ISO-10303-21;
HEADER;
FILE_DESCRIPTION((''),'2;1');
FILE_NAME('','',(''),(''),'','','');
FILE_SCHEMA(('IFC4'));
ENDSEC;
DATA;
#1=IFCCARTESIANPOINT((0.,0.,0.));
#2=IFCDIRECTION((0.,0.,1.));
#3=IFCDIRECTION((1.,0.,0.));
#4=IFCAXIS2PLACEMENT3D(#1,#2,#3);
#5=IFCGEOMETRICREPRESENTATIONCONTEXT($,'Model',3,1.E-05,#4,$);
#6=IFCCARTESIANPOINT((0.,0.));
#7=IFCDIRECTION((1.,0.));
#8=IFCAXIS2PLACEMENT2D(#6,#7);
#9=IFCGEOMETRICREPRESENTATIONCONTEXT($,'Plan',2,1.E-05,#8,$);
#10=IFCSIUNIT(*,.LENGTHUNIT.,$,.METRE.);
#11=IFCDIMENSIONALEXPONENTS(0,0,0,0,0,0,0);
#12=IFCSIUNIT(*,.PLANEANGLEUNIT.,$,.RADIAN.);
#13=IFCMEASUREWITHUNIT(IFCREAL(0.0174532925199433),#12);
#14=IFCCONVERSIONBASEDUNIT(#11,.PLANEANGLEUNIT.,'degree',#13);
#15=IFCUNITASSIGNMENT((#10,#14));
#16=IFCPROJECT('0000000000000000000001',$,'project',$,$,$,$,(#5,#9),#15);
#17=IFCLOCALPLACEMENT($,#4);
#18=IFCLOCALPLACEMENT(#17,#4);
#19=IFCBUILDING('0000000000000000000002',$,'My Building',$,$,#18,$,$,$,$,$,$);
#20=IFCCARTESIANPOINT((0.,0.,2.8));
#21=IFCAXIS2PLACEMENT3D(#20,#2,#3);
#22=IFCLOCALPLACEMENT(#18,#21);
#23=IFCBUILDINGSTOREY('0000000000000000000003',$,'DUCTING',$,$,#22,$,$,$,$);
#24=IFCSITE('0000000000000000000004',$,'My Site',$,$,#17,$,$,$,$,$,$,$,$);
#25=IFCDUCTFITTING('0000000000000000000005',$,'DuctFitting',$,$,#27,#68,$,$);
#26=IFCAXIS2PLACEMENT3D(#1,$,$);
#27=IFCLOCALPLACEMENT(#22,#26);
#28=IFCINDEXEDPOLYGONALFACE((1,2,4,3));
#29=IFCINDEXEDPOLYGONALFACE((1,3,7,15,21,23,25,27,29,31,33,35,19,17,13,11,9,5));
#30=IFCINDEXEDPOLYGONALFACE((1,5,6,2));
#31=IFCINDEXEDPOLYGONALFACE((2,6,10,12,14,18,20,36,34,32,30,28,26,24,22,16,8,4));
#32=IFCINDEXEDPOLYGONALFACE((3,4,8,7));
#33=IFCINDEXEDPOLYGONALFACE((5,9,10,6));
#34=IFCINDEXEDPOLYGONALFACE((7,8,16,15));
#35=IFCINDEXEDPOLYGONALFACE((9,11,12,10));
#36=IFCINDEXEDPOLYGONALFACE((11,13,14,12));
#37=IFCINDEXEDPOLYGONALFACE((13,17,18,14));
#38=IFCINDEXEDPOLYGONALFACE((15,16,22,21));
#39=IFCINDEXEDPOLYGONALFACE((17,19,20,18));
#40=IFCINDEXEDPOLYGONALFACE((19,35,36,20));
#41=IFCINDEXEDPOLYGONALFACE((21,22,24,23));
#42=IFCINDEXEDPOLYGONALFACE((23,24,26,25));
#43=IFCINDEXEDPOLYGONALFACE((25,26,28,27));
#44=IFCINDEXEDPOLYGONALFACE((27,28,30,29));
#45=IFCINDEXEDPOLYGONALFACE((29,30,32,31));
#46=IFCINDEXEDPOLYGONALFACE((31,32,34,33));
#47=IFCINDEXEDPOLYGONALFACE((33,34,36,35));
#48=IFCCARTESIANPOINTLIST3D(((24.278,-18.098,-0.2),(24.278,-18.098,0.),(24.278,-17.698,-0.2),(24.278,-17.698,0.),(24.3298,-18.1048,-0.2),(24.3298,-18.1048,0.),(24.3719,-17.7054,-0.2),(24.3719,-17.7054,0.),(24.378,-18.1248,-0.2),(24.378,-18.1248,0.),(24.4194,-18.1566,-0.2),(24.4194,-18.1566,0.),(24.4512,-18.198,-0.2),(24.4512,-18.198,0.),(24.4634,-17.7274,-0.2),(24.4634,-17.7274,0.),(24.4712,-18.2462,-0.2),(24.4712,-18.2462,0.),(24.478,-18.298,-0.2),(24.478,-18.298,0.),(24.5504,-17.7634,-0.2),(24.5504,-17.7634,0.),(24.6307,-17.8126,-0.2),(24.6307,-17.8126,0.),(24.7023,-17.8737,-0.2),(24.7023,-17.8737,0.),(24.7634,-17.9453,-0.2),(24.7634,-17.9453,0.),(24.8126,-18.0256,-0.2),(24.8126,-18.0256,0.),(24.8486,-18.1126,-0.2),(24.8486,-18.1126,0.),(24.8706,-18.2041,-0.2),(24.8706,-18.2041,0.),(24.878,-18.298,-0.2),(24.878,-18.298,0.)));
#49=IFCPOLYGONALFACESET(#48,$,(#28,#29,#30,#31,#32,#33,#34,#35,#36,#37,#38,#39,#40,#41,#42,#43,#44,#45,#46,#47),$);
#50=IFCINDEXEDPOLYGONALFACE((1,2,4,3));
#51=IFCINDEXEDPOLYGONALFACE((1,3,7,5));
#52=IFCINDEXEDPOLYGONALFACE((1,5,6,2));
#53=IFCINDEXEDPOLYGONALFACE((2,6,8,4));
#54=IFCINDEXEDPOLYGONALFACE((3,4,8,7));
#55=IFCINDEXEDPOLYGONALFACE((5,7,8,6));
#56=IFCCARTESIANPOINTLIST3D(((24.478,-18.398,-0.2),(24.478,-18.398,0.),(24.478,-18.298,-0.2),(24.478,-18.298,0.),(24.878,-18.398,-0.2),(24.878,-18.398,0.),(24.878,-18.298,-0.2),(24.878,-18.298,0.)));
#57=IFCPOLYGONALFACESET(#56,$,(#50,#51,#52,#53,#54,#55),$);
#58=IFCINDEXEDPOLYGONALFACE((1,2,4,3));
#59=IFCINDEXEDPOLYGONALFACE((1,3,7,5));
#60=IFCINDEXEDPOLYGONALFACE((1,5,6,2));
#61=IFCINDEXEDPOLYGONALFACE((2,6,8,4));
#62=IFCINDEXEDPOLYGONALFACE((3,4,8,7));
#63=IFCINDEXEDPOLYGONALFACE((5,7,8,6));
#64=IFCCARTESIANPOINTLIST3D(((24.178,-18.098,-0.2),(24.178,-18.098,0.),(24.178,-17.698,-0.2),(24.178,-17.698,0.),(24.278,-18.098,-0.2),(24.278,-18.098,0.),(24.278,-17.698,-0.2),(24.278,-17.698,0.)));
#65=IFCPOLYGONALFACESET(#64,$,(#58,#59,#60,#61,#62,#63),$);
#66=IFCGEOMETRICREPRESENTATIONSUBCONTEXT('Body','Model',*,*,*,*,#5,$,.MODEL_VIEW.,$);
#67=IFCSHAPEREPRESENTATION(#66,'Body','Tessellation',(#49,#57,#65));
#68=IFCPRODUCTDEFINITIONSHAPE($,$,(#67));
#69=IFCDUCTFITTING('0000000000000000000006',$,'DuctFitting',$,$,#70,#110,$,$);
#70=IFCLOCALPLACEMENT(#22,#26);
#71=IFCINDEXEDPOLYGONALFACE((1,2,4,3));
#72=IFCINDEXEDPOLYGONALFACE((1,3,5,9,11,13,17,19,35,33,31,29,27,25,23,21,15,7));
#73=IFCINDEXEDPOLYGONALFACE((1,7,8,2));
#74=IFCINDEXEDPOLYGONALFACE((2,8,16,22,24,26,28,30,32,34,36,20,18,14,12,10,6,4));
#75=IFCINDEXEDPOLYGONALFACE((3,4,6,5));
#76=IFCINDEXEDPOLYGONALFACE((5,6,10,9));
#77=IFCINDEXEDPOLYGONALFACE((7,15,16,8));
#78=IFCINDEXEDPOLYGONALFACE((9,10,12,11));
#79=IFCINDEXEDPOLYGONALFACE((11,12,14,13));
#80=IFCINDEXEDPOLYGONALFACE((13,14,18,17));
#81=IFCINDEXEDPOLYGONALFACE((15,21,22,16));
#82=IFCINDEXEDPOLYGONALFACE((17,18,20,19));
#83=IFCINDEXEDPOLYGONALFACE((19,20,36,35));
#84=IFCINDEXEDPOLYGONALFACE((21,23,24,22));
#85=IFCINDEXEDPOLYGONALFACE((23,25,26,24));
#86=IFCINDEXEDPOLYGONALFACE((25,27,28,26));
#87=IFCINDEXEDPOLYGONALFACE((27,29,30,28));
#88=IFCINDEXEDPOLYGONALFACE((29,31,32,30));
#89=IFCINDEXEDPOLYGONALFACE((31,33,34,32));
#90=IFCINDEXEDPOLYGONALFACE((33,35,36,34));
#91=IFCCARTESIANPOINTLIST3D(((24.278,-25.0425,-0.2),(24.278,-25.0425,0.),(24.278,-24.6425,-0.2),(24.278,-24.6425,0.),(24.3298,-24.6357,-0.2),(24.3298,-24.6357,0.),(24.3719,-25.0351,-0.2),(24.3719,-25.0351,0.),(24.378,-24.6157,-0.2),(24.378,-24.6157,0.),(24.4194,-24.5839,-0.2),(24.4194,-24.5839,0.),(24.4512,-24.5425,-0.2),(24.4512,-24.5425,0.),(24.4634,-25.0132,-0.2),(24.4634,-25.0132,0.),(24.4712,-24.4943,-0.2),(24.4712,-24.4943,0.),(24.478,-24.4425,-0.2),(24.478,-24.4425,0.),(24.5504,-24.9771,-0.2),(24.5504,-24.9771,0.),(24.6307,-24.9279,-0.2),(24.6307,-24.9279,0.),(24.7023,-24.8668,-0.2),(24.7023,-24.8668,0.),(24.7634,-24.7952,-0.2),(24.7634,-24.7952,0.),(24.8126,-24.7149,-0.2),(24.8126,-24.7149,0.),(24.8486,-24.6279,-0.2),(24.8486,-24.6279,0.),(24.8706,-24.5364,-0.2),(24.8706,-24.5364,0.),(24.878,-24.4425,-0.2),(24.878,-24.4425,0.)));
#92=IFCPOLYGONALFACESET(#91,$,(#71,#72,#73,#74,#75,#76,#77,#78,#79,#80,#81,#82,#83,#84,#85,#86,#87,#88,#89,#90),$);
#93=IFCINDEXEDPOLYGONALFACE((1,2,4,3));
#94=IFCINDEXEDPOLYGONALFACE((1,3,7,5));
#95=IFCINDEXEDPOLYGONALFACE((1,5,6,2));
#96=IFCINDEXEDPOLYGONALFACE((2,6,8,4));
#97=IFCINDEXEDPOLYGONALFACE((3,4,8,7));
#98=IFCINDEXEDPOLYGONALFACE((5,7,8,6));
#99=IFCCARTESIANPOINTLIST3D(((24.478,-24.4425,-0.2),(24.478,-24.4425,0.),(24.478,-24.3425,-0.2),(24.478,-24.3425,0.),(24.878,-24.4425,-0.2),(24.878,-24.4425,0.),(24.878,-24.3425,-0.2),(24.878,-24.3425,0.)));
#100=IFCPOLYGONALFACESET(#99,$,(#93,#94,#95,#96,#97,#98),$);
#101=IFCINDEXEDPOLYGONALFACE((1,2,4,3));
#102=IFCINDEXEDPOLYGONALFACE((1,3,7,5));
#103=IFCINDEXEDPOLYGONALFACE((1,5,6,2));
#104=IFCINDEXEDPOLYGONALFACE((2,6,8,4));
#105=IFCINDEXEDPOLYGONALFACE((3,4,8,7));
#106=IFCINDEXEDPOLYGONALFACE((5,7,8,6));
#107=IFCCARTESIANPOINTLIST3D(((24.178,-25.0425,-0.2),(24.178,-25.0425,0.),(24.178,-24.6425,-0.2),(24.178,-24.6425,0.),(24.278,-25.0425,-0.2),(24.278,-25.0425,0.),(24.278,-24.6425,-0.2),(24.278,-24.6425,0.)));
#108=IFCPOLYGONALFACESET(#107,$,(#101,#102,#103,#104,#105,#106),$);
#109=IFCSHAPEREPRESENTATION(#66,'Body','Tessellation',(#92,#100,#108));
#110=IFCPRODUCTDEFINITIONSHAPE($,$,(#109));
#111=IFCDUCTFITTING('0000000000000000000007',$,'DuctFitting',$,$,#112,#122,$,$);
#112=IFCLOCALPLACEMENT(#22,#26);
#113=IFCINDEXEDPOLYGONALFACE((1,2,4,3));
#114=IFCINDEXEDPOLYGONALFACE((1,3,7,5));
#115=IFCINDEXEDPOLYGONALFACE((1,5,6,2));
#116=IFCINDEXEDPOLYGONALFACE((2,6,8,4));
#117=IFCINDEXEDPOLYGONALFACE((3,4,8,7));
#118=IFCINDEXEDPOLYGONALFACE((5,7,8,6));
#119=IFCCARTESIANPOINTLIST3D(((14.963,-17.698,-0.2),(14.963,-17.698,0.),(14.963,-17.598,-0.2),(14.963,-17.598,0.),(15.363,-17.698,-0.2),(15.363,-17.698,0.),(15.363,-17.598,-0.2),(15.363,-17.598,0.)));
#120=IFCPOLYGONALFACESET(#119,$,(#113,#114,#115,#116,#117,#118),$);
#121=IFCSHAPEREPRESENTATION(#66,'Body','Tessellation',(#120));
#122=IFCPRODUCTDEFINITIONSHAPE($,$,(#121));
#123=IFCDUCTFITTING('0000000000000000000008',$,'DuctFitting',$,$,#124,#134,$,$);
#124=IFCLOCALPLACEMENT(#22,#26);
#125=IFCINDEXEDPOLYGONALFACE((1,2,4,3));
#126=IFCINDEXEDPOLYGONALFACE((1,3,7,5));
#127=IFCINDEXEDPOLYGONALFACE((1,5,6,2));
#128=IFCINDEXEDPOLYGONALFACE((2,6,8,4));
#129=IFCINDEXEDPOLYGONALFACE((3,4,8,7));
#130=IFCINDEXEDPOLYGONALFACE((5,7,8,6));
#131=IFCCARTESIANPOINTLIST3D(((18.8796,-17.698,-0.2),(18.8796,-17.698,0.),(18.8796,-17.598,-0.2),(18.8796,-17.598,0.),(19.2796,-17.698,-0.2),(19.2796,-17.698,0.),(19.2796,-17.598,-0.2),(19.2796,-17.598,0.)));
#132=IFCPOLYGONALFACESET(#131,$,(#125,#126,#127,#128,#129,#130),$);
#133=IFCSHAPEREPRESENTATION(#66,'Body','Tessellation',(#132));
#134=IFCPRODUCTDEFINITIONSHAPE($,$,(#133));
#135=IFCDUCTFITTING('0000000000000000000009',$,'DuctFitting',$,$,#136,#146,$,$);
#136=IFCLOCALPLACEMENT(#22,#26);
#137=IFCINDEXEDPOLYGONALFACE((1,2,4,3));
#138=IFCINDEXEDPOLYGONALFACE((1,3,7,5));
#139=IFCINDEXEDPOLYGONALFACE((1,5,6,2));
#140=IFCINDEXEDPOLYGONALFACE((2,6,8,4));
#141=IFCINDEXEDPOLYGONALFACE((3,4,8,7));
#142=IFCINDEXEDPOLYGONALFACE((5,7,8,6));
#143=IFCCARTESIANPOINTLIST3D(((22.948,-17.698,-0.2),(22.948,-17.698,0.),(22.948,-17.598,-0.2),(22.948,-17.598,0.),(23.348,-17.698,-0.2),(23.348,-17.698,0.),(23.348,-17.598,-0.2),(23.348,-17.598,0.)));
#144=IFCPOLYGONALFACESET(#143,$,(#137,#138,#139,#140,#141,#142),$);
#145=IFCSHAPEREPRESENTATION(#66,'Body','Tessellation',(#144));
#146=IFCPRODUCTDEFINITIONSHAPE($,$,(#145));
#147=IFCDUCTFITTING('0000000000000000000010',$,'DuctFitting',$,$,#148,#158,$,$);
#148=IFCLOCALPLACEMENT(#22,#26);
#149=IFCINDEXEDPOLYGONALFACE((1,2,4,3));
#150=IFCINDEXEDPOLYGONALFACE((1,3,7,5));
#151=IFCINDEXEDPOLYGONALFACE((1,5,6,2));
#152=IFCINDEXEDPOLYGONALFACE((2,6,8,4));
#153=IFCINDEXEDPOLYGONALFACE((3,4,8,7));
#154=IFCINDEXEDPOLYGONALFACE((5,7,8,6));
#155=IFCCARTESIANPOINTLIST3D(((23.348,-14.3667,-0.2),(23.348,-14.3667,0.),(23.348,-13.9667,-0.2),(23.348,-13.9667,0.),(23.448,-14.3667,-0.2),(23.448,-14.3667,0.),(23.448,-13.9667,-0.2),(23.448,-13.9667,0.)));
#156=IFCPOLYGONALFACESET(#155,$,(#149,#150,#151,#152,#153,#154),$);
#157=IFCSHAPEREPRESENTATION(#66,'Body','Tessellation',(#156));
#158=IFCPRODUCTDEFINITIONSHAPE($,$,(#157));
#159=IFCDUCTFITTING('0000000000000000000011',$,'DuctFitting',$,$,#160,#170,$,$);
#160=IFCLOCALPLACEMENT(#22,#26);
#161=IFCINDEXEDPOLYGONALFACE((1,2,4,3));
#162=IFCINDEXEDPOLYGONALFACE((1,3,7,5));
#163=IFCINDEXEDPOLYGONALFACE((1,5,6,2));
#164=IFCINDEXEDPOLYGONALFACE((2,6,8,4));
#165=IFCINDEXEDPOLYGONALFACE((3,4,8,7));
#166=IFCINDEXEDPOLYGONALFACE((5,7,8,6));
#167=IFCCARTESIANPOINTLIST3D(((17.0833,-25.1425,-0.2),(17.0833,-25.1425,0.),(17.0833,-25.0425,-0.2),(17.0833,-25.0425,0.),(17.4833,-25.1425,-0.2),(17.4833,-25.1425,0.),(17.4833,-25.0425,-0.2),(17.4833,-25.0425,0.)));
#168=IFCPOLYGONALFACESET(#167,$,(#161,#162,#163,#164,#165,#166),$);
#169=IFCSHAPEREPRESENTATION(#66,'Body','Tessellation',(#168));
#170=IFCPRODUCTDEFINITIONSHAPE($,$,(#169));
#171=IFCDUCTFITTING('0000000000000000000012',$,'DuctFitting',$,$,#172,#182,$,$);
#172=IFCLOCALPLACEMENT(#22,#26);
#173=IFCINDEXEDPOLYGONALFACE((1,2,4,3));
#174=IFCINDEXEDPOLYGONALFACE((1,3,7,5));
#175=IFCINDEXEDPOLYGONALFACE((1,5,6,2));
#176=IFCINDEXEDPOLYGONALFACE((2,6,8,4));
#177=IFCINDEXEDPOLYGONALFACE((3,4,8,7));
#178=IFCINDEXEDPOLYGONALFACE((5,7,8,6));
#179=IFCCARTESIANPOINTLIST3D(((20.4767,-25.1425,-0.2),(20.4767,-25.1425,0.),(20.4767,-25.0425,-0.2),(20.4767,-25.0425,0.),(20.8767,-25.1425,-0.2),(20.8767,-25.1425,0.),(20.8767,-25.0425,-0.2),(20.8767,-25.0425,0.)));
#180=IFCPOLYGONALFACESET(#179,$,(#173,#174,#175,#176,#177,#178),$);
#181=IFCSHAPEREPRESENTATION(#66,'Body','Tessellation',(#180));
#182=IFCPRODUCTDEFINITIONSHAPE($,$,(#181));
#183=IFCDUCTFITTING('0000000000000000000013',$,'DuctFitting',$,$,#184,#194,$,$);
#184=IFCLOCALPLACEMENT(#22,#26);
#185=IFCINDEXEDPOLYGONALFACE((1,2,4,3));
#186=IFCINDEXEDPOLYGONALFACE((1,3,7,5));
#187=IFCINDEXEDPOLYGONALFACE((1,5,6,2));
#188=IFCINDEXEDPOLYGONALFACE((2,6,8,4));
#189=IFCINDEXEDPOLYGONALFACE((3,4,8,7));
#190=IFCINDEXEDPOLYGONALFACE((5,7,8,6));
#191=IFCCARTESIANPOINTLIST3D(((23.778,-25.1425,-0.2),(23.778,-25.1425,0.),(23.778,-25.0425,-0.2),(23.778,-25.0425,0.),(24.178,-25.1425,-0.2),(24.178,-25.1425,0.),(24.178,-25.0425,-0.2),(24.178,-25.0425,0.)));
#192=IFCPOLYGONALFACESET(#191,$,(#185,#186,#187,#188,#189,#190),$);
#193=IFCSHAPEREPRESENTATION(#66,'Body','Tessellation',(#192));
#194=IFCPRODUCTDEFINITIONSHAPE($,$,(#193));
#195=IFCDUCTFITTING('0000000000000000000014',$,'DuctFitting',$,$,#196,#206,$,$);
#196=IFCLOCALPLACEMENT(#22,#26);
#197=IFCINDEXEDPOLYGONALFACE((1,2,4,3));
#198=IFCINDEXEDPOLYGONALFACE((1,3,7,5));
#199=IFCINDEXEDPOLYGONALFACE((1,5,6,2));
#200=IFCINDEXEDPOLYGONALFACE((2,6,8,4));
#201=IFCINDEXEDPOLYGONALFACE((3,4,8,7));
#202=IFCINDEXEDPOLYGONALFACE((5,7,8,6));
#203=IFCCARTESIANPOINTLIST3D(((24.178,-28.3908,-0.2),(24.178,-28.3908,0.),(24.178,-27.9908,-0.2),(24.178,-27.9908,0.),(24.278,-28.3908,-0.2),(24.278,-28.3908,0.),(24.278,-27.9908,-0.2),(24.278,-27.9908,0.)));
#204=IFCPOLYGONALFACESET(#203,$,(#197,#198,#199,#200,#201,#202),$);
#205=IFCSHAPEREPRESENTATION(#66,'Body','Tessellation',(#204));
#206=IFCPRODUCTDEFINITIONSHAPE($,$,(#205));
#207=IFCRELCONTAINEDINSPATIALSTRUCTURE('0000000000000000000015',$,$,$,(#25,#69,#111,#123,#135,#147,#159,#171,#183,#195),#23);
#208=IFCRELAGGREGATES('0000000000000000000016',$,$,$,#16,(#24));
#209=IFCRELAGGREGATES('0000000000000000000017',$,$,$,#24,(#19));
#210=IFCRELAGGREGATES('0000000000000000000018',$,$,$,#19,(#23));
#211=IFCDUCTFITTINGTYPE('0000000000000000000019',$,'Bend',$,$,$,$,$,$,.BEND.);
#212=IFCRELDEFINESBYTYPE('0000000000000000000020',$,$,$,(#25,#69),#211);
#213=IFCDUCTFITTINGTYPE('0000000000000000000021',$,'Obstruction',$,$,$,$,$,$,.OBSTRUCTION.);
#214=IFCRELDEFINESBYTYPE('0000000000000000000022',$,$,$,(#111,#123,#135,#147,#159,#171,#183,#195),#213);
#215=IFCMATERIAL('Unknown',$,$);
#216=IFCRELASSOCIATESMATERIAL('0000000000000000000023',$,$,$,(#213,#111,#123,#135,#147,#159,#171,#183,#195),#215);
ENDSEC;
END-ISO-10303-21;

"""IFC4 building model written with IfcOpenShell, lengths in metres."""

from ifc_helpers import new_model, entity, si_unit, converted_unit, frame, origin_with_axes, origin_2d_with_axis, place, context, subcontext, project, spatial, line, arc, indexed_curve, rectangle, outline, extrude, source, transform, mapped, material, material_profile, profile_set, profile_usage, type_object, type_shapes, element, save


model = new_model("IFC4")

# Units and contexts
model_context = context("Model", 3, precision=1e-05, world=origin_with_axes())
plan_context = context("Plan", 2, precision=1e-05, world=origin_2d_with_axis())
body_context = subcontext(model_context, "Body", "Model", "MODEL_VIEW")
ifc_project = project(units=[si_unit("LENGTHUNIT", "METRE"), converted_unit("PLANEANGLEUNIT", "degree", entity("IfcReal", 0.0174532925199433), si_unit("PLANEANGLEUNIT", "RADIAN"), dimensions=[0, 0, 0, 0, 0, 0, 0])], contexts=[model_context, plan_context])

# Site, building, storey
site_placement = place(None, origin_with_axes())
site = spatial("IfcSite", under=ifc_project, at=site_placement, Name="My Site")
building_placement = place(site_placement, origin_with_axes())
building = spatial("IfcBuilding", under=site, at=building_placement, Name="My Building")
storey_placement = place(building_placement, frame((0.0, 0.0, 2.8), z_axis=(0.0, 0.0, 1.0), x_axis=(1.0, 0.0, 0.0)))
storey = spatial("IfcBuildingStorey", under=building, at=storey_placement, Name="DUCTING")

# Shared definitions
ifc_material = material(Name="Unknown")

# Duct fittings
duct_fitting_type_1 = type_object("IfcDuctFittingType", Name="Bend", PredefinedType="BEND")
shared_shape = source(origin_with_axes(), body_context, "Body", "SweptSolid", [
    extrude(outline(indexed_curve([(0.2, 0.0), (0.2586, -0.1414), (0.4, -0.2), (0.4, -0.6), (-0.0243, -0.4243), (-0.2, 0.0)], segments=[arc(1, 2, 3), line(3, 4), arc(4, 5, 6), line(6, 1)])), frame((0.0, -0.1, -0.1), z_axis=(0.0, -1.0, 0.0), x_axis=(1.0, 0.0, 0.0)), (0.0, 0.0, -1.0), 0.2),
    extrude(rectangle(XDim=0.4, YDim=0.2), origin_with_axes(), (0.0, 0.0, -1.0), 0.1),
    extrude(rectangle(XDim=0.4, YDim=0.2), frame((0.4, 0.0, -0.5), z_axis=(1.0, 0.0, 0.0), x_axis=(0.0, 0.0, 1.0)), (0.0, 0.0, 1.0), 0.1),
])
type_shapes(duct_fitting_type_1, [shared_shape])
for number, where, z_axis, x_axis, name in (
    (1, (24.678, -18.398, -0.1), (0.0, -1.0, 0.0), (-1.0, 0.0, 0.0), "DuctFitting"),
    (2, (24.678, -24.3425, -0.1), (0.0, 1.0, 0.0), (-1.0, 0.0, 0.0), "DuctFitting"),
):
    element("IfcDuctFitting", number, at=place(storey_placement, frame(where, z_axis=z_axis, x_axis=x_axis)), inside=storey, type_object=duct_fitting_type_1, Name=name, context=body_context, shape_type="MappedRepresentation", body=[
        mapped(shared_shape, transform((0.0, 0.0, 0.0), x_axis=(1.0, 0.0, 0.0), y_axis=(0.0, 1.0, 0.0), z_axis=(0.0, 0.0, 1.0), scale=1.0)),
    ])
ifc_material_profile_1 = material_profile(ifc_material, rectangle(XDim=0.4, YDim=0.2))
ifc_profile_set_1 = profile_set([ifc_material_profile_1])
ifc_profile_usage_1 = profile_usage(ifc_profile_set_1, cardinal=5)
duct_fitting_type_2 = type_object("IfcDuctFittingType", Name="Obstruction", PredefinedType="OBSTRUCTION", material=ifc_profile_set_1)
duct_fitting_1_placement = place(storey_placement, frame((15.163, -17.698, -0.1), z_axis=(0.0, 1.0, 0.0), x_axis=(-1.0, 0.0, 0.0)))
element("IfcDuctFitting", 3, at=duct_fitting_1_placement, inside=storey, type_object=duct_fitting_type_2, material=ifc_profile_usage_1, Name="DuctFitting", context=body_context, shape_type="SweptSolid", body=[
    extrude(rectangle(XDim=0.4, YDim=0.2), origin_with_axes(), (0.0, 0.0, 1.0), 0.1),
])
ifc_profile_usage_2 = profile_usage(ifc_profile_set_1, cardinal=5)
duct_fitting_2_placement = place(storey_placement, frame((19.0796, -17.698, -0.1), z_axis=(0.0, 1.0, 0.0), x_axis=(-1.0, 0.0, 0.0)))
element("IfcDuctFitting", 4, at=duct_fitting_2_placement, inside=storey, type_object=duct_fitting_type_2, material=ifc_profile_usage_2, Name="DuctFitting", context=body_context, shape_type="SweptSolid", body=[
    extrude(rectangle(XDim=0.4, YDim=0.2), origin_with_axes(), (0.0, 0.0, 1.0), 0.1),
])
ifc_profile_usage_3 = profile_usage(ifc_profile_set_1, cardinal=5)
duct_fitting_3_placement = place(storey_placement, frame((23.148, -17.698, -0.1), z_axis=(0.0, 1.0, 0.0), x_axis=(-1.0, 0.0, 0.0)))
element("IfcDuctFitting", 5, at=duct_fitting_3_placement, inside=storey, type_object=duct_fitting_type_2, material=ifc_profile_usage_3, Name="DuctFitting", context=body_context, shape_type="SweptSolid", body=[
    extrude(rectangle(XDim=0.4, YDim=0.2), origin_with_axes(), (0.0, 0.0, 1.0), 0.1),
])
ifc_profile_usage_4 = profile_usage(ifc_profile_set_1, cardinal=5)
duct_fitting_4_placement = place(storey_placement, frame((23.348, -14.1667, -0.1), z_axis=(1.0, 0.0, 0.0), x_axis=(0.0, 1.0, 0.0)))
element("IfcDuctFitting", 6, at=duct_fitting_4_placement, inside=storey, type_object=duct_fitting_type_2, material=ifc_profile_usage_4, Name="DuctFitting", context=body_context, shape_type="SweptSolid", body=[
    extrude(rectangle(XDim=0.4, YDim=0.2), origin_with_axes(), (0.0, 0.0, 1.0), 0.1),
])
ifc_profile_usage_5 = profile_usage(ifc_profile_set_1, cardinal=5)
duct_fitting_5_placement = place(storey_placement, frame((17.2833, -25.0425, -0.1), z_axis=(0.0, -1.0, 0.0), x_axis=(1.0, 0.0, 0.0)))
element("IfcDuctFitting", 7, at=duct_fitting_5_placement, inside=storey, type_object=duct_fitting_type_2, material=ifc_profile_usage_5, Name="DuctFitting", context=body_context, shape_type="SweptSolid", body=[
    extrude(rectangle(XDim=0.4, YDim=0.2), origin_with_axes(), (0.0, 0.0, 1.0), 0.1),
])
ifc_profile_usage_6 = profile_usage(ifc_profile_set_1, cardinal=5)
duct_fitting_6_placement = place(storey_placement, frame((20.6767, -25.0425, -0.1), z_axis=(0.0, -1.0, 0.0), x_axis=(1.0, 0.0, 0.0)))
element("IfcDuctFitting", 8, at=duct_fitting_6_placement, inside=storey, type_object=duct_fitting_type_2, material=ifc_profile_usage_6, Name="DuctFitting", context=body_context, shape_type="SweptSolid", body=[
    extrude(rectangle(XDim=0.4, YDim=0.2), origin_with_axes(), (0.0, 0.0, 1.0), 0.1),
])
ifc_profile_usage_7 = profile_usage(ifc_profile_set_1, cardinal=5)
duct_fitting_7_placement = place(storey_placement, frame((23.978, -25.1425, -0.1), z_axis=(0.0, 1.0, 0.0), x_axis=(-1.0, 0.0, 0.0)))
element("IfcDuctFitting", 9, at=duct_fitting_7_placement, inside=storey, type_object=duct_fitting_type_2, material=ifc_profile_usage_7, Name="DuctFitting", context=body_context, shape_type="SweptSolid", body=[
    extrude(rectangle(XDim=0.4, YDim=0.2), origin_with_axes(), (0.0, 0.0, 1.0), 0.1),
])
ifc_profile_usage_8 = profile_usage(ifc_profile_set_1, cardinal=5)
duct_fitting_8_placement = place(storey_placement, frame((24.178, -28.1908, -0.1), z_axis=(1.0, 0.0, 0.0), x_axis=(0.0, 1.0, 0.0)))
element("IfcDuctFitting", 10, at=duct_fitting_8_placement, inside=storey, type_object=duct_fitting_type_2, material=ifc_profile_usage_8, Name="DuctFitting", context=body_context, shape_type="SweptSolid", body=[
    extrude(rectangle(XDim=0.4, YDim=0.2), origin_with_axes(), (0.0, 0.0, 1.0), 0.1),
])

save(model, "model.ifc")
